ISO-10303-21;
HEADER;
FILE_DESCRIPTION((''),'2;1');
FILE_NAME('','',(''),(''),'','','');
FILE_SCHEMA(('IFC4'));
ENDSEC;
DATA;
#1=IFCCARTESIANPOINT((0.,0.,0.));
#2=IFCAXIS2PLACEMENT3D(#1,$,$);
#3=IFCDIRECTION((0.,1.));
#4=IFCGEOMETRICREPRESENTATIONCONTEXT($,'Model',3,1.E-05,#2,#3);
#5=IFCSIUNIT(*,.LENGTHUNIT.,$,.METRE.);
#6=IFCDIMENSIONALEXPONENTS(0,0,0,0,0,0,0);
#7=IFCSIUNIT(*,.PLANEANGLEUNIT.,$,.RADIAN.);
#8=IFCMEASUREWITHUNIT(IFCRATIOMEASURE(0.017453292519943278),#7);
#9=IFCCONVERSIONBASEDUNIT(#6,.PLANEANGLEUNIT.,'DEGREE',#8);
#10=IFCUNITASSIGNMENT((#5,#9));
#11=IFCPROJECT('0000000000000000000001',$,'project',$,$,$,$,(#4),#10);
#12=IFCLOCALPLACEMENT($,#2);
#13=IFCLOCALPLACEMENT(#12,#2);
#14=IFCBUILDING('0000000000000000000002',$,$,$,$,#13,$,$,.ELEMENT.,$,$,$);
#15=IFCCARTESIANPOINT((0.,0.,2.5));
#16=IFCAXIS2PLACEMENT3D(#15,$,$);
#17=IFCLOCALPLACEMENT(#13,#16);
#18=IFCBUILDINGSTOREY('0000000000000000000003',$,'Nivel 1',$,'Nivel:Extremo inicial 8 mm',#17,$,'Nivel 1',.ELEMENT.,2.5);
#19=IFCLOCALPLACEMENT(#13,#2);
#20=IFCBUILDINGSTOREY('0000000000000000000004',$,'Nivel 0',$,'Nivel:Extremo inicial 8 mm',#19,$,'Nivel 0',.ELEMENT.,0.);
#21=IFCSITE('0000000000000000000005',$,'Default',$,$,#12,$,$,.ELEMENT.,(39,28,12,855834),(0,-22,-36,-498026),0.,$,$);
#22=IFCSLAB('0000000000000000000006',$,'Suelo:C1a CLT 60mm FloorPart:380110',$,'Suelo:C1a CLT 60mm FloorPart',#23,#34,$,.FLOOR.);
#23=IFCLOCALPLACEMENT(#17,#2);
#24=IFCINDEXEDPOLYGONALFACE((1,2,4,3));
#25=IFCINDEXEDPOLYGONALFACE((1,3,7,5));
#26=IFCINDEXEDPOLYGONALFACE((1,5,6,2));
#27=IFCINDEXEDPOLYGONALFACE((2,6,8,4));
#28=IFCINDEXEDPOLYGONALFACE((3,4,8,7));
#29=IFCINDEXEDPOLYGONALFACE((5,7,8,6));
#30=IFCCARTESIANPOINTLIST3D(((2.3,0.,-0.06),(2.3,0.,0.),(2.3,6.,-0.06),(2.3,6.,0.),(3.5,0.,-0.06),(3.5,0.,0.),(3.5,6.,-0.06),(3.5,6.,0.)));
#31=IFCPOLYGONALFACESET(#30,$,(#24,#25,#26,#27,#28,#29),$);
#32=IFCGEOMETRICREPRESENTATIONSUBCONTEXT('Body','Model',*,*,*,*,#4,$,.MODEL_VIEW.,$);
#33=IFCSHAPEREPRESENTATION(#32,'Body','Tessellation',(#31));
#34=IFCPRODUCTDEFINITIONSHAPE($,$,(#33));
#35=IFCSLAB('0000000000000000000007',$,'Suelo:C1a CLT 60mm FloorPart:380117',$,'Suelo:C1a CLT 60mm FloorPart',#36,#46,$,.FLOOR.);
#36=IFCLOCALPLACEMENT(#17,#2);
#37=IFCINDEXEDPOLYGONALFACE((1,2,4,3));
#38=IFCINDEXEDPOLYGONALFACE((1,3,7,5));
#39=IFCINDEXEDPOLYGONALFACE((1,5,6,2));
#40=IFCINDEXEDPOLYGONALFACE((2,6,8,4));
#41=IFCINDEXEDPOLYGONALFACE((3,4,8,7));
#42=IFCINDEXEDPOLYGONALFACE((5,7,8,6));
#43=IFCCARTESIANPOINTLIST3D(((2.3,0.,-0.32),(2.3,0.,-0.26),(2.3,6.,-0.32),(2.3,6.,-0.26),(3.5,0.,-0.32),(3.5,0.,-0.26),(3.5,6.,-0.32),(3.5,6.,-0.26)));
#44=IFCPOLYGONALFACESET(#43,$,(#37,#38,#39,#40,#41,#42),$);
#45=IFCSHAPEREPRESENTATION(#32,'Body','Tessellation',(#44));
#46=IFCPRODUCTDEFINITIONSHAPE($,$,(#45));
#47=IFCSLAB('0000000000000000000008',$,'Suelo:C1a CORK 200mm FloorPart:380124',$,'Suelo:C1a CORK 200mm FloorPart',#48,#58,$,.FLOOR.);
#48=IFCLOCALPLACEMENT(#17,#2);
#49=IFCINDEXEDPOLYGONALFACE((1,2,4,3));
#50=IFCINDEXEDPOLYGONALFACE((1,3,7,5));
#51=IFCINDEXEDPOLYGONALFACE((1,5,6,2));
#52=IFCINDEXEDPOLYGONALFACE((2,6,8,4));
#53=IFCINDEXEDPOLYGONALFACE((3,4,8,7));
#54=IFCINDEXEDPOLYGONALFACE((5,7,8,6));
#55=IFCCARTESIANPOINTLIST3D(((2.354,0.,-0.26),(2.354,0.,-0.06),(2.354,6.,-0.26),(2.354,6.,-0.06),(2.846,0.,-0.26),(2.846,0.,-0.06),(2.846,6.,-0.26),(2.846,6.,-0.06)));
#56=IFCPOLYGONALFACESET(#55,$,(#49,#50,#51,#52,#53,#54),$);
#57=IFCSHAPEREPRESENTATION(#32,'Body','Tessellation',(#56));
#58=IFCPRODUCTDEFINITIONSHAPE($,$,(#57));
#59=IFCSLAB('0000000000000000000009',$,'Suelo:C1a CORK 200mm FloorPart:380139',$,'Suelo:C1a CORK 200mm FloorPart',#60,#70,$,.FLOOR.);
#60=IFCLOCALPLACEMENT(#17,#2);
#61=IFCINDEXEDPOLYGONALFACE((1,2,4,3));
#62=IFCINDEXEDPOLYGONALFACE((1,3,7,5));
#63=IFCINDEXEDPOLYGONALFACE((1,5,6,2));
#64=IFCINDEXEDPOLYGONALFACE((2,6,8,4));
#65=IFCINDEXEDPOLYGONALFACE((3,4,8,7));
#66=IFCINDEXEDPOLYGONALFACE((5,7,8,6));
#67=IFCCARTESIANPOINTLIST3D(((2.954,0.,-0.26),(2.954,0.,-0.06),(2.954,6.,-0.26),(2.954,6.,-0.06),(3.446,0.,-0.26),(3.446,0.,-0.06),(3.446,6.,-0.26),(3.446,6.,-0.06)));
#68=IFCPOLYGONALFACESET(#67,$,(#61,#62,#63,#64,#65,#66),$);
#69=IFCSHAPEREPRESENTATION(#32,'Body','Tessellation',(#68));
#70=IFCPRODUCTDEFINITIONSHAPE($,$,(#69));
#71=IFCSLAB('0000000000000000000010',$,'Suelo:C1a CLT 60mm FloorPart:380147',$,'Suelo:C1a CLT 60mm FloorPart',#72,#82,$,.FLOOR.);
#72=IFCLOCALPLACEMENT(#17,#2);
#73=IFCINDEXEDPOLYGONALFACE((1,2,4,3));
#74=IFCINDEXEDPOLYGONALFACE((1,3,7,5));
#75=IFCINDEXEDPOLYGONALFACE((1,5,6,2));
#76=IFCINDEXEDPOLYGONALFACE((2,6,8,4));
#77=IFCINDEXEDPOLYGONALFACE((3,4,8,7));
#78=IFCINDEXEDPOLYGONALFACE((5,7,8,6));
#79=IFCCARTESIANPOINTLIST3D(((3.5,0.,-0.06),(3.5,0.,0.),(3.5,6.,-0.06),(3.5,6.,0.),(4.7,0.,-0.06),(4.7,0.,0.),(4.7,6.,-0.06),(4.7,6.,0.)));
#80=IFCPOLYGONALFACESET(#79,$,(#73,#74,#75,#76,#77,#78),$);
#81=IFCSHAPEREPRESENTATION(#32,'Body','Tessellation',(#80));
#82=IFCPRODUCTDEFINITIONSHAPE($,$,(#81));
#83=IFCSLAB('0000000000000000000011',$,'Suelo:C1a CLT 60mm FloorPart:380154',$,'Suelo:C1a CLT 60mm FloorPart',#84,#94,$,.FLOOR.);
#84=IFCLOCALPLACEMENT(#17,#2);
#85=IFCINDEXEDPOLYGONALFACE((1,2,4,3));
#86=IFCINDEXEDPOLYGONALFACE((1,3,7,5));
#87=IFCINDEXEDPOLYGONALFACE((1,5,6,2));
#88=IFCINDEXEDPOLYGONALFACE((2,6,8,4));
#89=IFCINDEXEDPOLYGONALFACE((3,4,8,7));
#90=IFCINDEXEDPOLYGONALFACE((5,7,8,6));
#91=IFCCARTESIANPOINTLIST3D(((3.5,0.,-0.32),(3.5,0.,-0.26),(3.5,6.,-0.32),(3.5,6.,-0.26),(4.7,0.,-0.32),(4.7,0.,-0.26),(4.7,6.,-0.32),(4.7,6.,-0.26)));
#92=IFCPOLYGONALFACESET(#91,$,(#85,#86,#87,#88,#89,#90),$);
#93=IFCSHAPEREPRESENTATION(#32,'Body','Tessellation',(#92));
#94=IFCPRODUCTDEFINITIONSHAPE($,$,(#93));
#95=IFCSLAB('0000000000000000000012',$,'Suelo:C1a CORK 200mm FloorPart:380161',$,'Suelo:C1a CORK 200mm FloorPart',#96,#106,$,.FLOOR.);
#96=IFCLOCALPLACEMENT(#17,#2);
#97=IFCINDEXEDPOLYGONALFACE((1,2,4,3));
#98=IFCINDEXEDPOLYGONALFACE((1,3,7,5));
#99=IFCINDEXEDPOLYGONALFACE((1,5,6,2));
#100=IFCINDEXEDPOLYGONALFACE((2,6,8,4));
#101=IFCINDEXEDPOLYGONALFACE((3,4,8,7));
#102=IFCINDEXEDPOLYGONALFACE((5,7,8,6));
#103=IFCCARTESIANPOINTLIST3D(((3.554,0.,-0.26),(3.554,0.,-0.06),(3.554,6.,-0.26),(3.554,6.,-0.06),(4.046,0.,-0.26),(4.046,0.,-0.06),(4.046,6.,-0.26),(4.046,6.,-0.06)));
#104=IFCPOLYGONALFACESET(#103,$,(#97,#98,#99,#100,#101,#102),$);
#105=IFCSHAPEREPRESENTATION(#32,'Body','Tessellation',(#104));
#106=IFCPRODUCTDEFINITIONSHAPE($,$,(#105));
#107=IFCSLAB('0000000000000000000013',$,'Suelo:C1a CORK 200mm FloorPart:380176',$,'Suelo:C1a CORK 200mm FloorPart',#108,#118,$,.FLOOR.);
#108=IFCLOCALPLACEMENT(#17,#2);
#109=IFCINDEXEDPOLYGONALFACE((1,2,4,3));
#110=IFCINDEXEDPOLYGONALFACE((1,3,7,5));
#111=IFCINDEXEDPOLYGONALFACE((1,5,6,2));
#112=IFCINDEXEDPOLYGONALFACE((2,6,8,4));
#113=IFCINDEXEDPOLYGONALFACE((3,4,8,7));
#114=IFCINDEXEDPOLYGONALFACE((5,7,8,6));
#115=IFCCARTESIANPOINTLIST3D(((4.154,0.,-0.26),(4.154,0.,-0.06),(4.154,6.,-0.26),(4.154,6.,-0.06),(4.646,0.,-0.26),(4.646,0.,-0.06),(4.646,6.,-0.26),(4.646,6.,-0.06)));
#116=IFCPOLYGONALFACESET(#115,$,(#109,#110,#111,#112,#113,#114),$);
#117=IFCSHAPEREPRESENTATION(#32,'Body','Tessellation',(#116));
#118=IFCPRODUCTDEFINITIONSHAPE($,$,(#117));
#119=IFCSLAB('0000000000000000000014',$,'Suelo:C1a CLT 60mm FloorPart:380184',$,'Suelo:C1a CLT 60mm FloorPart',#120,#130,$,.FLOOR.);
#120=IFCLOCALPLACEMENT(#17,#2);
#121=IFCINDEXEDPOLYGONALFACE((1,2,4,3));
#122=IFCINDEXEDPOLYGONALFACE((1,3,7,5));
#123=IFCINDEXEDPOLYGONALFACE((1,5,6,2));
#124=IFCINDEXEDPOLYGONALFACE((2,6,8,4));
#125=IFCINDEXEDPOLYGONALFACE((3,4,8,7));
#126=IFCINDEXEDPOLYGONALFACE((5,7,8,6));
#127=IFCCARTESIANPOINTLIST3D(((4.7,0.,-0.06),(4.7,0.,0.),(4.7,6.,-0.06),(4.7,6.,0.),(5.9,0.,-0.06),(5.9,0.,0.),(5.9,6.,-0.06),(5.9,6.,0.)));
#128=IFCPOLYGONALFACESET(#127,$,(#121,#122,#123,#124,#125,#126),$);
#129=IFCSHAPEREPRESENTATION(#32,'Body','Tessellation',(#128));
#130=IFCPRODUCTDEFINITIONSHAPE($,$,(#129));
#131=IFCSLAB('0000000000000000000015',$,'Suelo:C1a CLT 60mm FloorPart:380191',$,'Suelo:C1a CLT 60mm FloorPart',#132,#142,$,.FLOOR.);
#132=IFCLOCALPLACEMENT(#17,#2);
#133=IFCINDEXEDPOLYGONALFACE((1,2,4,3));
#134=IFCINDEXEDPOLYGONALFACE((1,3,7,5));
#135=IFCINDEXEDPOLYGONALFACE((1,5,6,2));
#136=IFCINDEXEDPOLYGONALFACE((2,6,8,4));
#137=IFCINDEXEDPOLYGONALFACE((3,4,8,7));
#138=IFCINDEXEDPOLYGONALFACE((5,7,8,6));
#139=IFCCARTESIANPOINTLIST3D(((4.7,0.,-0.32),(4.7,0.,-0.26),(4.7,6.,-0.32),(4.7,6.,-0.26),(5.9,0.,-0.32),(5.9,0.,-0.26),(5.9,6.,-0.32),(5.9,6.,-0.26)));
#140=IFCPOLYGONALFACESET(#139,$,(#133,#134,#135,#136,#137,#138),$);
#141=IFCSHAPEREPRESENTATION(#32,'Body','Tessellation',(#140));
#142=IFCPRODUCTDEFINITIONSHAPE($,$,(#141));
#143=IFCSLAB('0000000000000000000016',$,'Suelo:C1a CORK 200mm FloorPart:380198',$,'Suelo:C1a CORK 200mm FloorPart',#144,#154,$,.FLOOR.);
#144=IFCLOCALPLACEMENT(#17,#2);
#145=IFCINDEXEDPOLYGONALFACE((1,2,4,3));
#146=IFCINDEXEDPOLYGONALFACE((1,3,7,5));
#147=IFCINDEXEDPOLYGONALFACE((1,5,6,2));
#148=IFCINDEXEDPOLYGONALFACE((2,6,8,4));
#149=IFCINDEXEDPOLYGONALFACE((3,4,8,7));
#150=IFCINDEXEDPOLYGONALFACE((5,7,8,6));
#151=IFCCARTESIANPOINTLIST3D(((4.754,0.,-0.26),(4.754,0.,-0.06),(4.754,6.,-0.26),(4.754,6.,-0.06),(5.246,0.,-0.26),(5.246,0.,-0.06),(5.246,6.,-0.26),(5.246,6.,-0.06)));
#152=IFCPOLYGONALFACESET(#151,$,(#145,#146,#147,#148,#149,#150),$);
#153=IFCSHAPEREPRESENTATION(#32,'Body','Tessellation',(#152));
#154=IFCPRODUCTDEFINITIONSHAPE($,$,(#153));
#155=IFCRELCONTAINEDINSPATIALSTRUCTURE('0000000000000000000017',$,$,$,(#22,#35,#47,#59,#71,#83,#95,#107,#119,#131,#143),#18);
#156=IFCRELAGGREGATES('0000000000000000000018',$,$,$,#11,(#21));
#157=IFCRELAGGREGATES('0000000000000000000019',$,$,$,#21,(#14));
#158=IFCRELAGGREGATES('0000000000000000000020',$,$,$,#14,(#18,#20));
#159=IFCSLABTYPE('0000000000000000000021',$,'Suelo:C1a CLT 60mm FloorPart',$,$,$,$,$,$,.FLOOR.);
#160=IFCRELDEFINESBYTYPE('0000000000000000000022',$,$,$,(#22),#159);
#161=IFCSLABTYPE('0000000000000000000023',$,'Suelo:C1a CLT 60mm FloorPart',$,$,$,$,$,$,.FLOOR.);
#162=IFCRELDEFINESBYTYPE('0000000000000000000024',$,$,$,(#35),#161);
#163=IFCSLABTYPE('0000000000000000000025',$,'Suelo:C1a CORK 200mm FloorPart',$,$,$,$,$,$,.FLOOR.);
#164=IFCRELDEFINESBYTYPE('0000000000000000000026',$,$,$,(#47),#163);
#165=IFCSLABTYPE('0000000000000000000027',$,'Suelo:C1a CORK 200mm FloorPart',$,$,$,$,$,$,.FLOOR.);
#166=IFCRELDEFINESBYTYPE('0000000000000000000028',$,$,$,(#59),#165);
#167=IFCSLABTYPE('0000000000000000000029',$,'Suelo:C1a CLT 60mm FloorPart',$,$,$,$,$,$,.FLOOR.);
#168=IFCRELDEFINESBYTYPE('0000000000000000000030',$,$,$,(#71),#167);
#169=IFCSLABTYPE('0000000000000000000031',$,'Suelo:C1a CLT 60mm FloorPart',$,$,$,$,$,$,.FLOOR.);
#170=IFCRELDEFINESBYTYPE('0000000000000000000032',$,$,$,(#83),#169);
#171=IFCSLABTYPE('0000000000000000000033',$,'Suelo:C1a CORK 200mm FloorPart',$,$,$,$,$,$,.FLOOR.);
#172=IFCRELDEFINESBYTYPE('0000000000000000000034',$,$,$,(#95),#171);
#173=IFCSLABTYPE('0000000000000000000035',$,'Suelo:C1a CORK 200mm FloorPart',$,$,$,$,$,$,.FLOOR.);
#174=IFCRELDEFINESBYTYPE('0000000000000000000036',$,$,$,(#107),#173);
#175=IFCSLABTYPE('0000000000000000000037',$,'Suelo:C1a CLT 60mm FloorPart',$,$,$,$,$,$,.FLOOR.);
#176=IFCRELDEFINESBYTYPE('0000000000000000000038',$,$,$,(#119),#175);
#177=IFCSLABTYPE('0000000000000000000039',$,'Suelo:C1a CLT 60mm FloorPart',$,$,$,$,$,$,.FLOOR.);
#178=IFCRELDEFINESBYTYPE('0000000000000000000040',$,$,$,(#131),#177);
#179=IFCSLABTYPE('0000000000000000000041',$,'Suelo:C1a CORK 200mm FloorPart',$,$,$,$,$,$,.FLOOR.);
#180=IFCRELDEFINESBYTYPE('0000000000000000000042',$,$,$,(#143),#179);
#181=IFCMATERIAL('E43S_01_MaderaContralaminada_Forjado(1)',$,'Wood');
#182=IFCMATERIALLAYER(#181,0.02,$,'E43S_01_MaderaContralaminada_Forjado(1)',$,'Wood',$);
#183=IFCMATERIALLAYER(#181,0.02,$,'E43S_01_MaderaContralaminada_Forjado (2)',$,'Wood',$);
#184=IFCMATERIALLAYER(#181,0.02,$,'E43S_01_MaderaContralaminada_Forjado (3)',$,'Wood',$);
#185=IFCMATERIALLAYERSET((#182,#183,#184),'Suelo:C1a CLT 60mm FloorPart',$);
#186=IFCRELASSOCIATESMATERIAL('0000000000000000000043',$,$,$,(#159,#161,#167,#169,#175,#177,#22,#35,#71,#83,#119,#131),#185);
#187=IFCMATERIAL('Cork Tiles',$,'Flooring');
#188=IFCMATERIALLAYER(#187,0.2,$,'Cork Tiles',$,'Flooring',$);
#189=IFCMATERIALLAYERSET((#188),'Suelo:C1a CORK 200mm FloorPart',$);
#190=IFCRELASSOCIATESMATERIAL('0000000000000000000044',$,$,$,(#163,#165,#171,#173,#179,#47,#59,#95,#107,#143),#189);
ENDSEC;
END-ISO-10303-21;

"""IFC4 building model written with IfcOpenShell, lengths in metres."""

from ifc_helpers import new_model, entity, si_unit, converted_unit, direction, frame, frame_2d, origin, origin_2d_with_axis, place, context, subcontext, project, spatial, rectangle, extrude, material, layer, layer_set, layer_usage, type_object, element, save


model = new_model("IFC4")

# Units and contexts
model_context = context("Model", 3, precision=1e-05, world=origin(), true_north=direction((0.0, 1.0)))
body_context = subcontext(model_context, "Body", "Model", "MODEL_VIEW")
ifc_project = project(units=[si_unit("LENGTHUNIT", "METRE"), converted_unit("PLANEANGLEUNIT", "DEGREE", entity("IfcRatioMeasure", 0.017453292519943278), si_unit("PLANEANGLEUNIT", "RADIAN"), dimensions=[0, 0, 0, 0, 0, 0, 0])], contexts=[model_context])

# Site, building, storey
site_placement = place(None, origin())
site = spatial("IfcSite", under=ifc_project, at=site_placement, Name="Default", CompositionType="ELEMENT", RefLatitude=(39, 28, 12, 855834), RefLongitude=(0, -22, -36, -498026), RefElevation=0.0)
building_placement = place(site_placement, origin())
building = spatial("IfcBuilding", under=site, at=building_placement, CompositionType="ELEMENT")
storey_1_placement = place(building_placement, frame((0.0, 0.0, 2.5)))
storey_1 = spatial("IfcBuildingStorey", under=building, at=storey_1_placement, Name="Nivel 1", ObjectType="Nivel:Extremo inicial 8 mm", LongName="Nivel 1", CompositionType="ELEMENT", Elevation=2.5)

# Slabs
ifc_material_1 = material(Name="E43S_01_MaderaContralaminada_Forjado(1)", Category="Wood")
ifc_layer_1 = layer(ifc_material_1, 0.02, Name="E43S_01_MaderaContralaminada_Forjado(1)", Category="Wood")
ifc_layer_2 = layer(ifc_material_1, 0.02, Name="E43S_01_MaderaContralaminada_Forjado (2)", Category="Wood")
ifc_layer_3 = layer(ifc_material_1, 0.02, Name="E43S_01_MaderaContralaminada_Forjado (3)", Category="Wood")
ifc_layer_set_1 = layer_set([ifc_layer_1, ifc_layer_2, ifc_layer_3], Name="Suelo:C1a CLT 60mm FloorPart")
ifc_layer_usage_1 = layer_usage(ifc_layer_set_1, "AXIS3", "POSITIVE", 0.0)
slab_type_1 = type_object("IfcSlabType", Name="Suelo:C1a CLT 60mm FloorPart", PredefinedType="FLOOR", material=ifc_layer_set_1)
slab_1_placement = place(storey_1_placement, origin())
element("IfcSlab", 1, at=slab_1_placement, inside=storey_1, type_object=slab_type_1, material=ifc_layer_usage_1, Name="Suelo:C1a CLT 60mm FloorPart:380110", ObjectType="Suelo:C1a CLT 60mm FloorPart", PredefinedType="FLOOR", context=body_context, shape_type="SweptSolid", body=[
    extrude(rectangle(XDim=6.0, YDim=1.2, at=frame_2d((0.0, 0.0), x_axis=(1.0, 0.0))), frame((2.9, 3.0, 0.0), z_axis=(0.0, 0.0, -1.0), x_axis=(0.0, 1.0, 0.0)), (0.0, 0.0, 1.0), 0.06),
])
ifc_layer_usage_2 = layer_usage(ifc_layer_set_1, "AXIS3", "POSITIVE", 0.0)
slab_type_2 = type_object("IfcSlabType", Name="Suelo:C1a CLT 60mm FloorPart", PredefinedType="FLOOR", material=ifc_layer_set_1)
slab_2_placement = place(storey_1_placement, origin())
element("IfcSlab", 2, at=slab_2_placement, inside=storey_1, type_object=slab_type_2, material=ifc_layer_usage_2, Name="Suelo:C1a CLT 60mm FloorPart:380117", ObjectType="Suelo:C1a CLT 60mm FloorPart", PredefinedType="FLOOR", context=body_context, shape_type="SweptSolid", body=[
    extrude(rectangle(XDim=6.0, YDim=1.2, at=frame_2d((0.0, 0.0), x_axis=(1.0, 0.0))), frame((2.9, 3.0, -0.26), z_axis=(0.0, 0.0, -1.0), x_axis=(0.0, 1.0, 0.0)), (0.0, 0.0, 1.0), 0.06),
])
ifc_material_2 = material(Name="Cork Tiles", Category="Flooring")
ifc_layer_4 = layer(ifc_material_2, 0.2, Name="Cork Tiles", Category="Flooring")
ifc_layer_set_2 = layer_set([ifc_layer_4], Name="Suelo:C1a CORK 200mm FloorPart")
ifc_layer_usage_3 = layer_usage(ifc_layer_set_2, "AXIS3", "POSITIVE", 0.0)
slab_type_3 = type_object("IfcSlabType", Name="Suelo:C1a CORK 200mm FloorPart", PredefinedType="FLOOR", material=ifc_layer_set_2)
slab_3_placement = place(storey_1_placement, origin())
element("IfcSlab", 3, at=slab_3_placement, inside=storey_1, type_object=slab_type_3, material=ifc_layer_usage_3, Name="Suelo:C1a CORK 200mm FloorPart:380124", ObjectType="Suelo:C1a CORK 200mm FloorPart", PredefinedType="FLOOR", context=body_context, shape_type="SweptSolid", body=[
    extrude(rectangle(XDim=6.0, YDim=0.492, at=frame_2d((0.0, 0.0), x_axis=(1.0, 0.0))), frame((2.6, 3.0, -0.06), z_axis=(0.0, 0.0, -1.0), x_axis=(0.0, 1.0, 0.0)), (0.0, 0.0, 1.0), 0.2),
])
ifc_layer_usage_4 = layer_usage(ifc_layer_set_2, "AXIS3", "POSITIVE", 0.0)
slab_type_4 = type_object("IfcSlabType", Name="Suelo:C1a CORK 200mm FloorPart", PredefinedType="FLOOR", material=ifc_layer_set_2)
slab_4_placement = place(storey_1_placement, origin())
element("IfcSlab", 4, at=slab_4_placement, inside=storey_1, type_object=slab_type_4, material=ifc_layer_usage_4, Name="Suelo:C1a CORK 200mm FloorPart:380139", ObjectType="Suelo:C1a CORK 200mm FloorPart", PredefinedType="FLOOR", context=body_context, shape_type="SweptSolid", body=[
    extrude(rectangle(XDim=6.0, YDim=0.492, at=frame_2d((0.0, 0.0), x_axis=(1.0, 0.0))), frame((3.2, 3.0, -0.06), z_axis=(0.0, 0.0, -1.0), x_axis=(0.0, 1.0, 0.0)), (0.0, 0.0, 1.0), 0.2),
])
ifc_layer_usage_5 = layer_usage(ifc_layer_set_1, "AXIS3", "POSITIVE", 0.0)
slab_type_5 = type_object("IfcSlabType", Name="Suelo:C1a CLT 60mm FloorPart", PredefinedType="FLOOR", material=ifc_layer_set_1)
slab_5_placement = place(storey_1_placement, origin())
element("IfcSlab", 5, at=slab_5_placement, inside=storey_1, type_object=slab_type_5, material=ifc_layer_usage_5, Name="Suelo:C1a CLT 60mm FloorPart:380147", ObjectType="Suelo:C1a CLT 60mm FloorPart", PredefinedType="FLOOR", context=body_context, shape_type="SweptSolid", body=[
    extrude(rectangle(XDim=6.0, YDim=1.2, at=frame_2d((0.0, 0.0), x_axis=(1.0, 0.0))), frame((4.1, 3.0, 0.0), z_axis=(0.0, 0.0, -1.0), x_axis=(0.0, 1.0, 0.0)), (0.0, 0.0, 1.0), 0.06),
])
ifc_layer_usage_6 = layer_usage(ifc_layer_set_1, "AXIS3", "POSITIVE", 0.0)
slab_type_6 = type_object("IfcSlabType", Name="Suelo:C1a CLT 60mm FloorPart", PredefinedType="FLOOR", material=ifc_layer_set_1)
slab_6_placement = place(storey_1_placement, origin())
element("IfcSlab", 6, at=slab_6_placement, inside=storey_1, type_object=slab_type_6, material=ifc_layer_usage_6, Name="Suelo:C1a CLT 60mm FloorPart:380154", ObjectType="Suelo:C1a CLT 60mm FloorPart", PredefinedType="FLOOR", context=body_context, shape_type="SweptSolid", body=[
    extrude(rectangle(XDim=6.0, YDim=1.2, at=frame_2d((0.0, 0.0), x_axis=(1.0, 0.0))), frame((4.1, 3.0, -0.26), z_axis=(0.0, 0.0, -1.0), x_axis=(0.0, 1.0, 0.0)), (0.0, 0.0, 1.0), 0.06),
])
ifc_layer_usage_7 = layer_usage(ifc_layer_set_2, "AXIS3", "POSITIVE", 0.0)
slab_type_7 = type_object("IfcSlabType", Name="Suelo:C1a CORK 200mm FloorPart", PredefinedType="FLOOR", material=ifc_layer_set_2)
slab_7_placement = place(storey_1_placement, origin())
element("IfcSlab", 7, at=slab_7_placement, inside=storey_1, type_object=slab_type_7, material=ifc_layer_usage_7, Name="Suelo:C1a CORK 200mm FloorPart:380161", ObjectType="Suelo:C1a CORK 200mm FloorPart", PredefinedType="FLOOR", context=body_context, shape_type="SweptSolid", body=[
    extrude(rectangle(XDim=6.0, YDim=0.492, at=frame_2d((0.0, 0.0), x_axis=(1.0, 0.0))), frame((3.8, 3.0, -0.06), z_axis=(0.0, 0.0, -1.0), x_axis=(0.0, 1.0, 0.0)), (0.0, 0.0, 1.0), 0.2),
])
ifc_layer_usage_8 = layer_usage(ifc_layer_set_2, "AXIS3", "POSITIVE", 0.0)
slab_type_8 = type_object("IfcSlabType", Name="Suelo:C1a CORK 200mm FloorPart", PredefinedType="FLOOR", material=ifc_layer_set_2)
slab_8_placement = place(storey_1_placement, origin())
element("IfcSlab", 8, at=slab_8_placement, inside=storey_1, type_object=slab_type_8, material=ifc_layer_usage_8, Name="Suelo:C1a CORK 200mm FloorPart:380176", ObjectType="Suelo:C1a CORK 200mm FloorPart", PredefinedType="FLOOR", context=body_context, shape_type="SweptSolid", body=[
    extrude(rectangle(XDim=6.0, YDim=0.492, at=frame_2d((0.0, 0.0), x_axis=(1.0, 0.0))), frame((4.4, 3.0, -0.06), z_axis=(0.0, 0.0, -1.0), x_axis=(0.0, 1.0, 0.0)), (0.0, 0.0, 1.0), 0.2),
])
ifc_layer_usage_9 = layer_usage(ifc_layer_set_1, "AXIS3", "POSITIVE", 0.0)
slab_type_9 = type_object("IfcSlabType", Name="Suelo:C1a CLT 60mm FloorPart", PredefinedType="FLOOR", material=ifc_layer_set_1)
slab_9_placement = place(storey_1_placement, origin())
element("IfcSlab", 9, at=slab_9_placement, inside=storey_1, type_object=slab_type_9, material=ifc_layer_usage_9, Name="Suelo:C1a CLT 60mm FloorPart:380184", ObjectType="Suelo:C1a CLT 60mm FloorPart", PredefinedType="FLOOR", context=body_context, shape_type="SweptSolid", body=[
    extrude(rectangle(XDim=6.0, YDim=1.2, at=frame_2d((0.0, 0.0), x_axis=(1.0, 0.0))), frame((5.3, 3.0, 0.0), z_axis=(0.0, 0.0, -1.0), x_axis=(0.0, 1.0, 0.0)), (0.0, 0.0, 1.0), 0.06),
])
ifc_layer_usage_10 = layer_usage(ifc_layer_set_1, "AXIS3", "POSITIVE", 0.0)
slab_type_10 = type_object("IfcSlabType", Name="Suelo:C1a CLT 60mm FloorPart", PredefinedType="FLOOR", material=ifc_layer_set_1)
slab_10_placement = place(storey_1_placement, origin())
element("IfcSlab", 10, at=slab_10_placement, inside=storey_1, type_object=slab_type_10, material=ifc_layer_usage_10, Name="Suelo:C1a CLT 60mm FloorPart:380191", ObjectType="Suelo:C1a CLT 60mm FloorPart", PredefinedType="FLOOR", context=body_context, shape_type="SweptSolid", body=[
    extrude(rectangle(XDim=6.0, YDim=1.2, at=frame_2d((0.0, 0.0), x_axis=(1.0, 0.0))), frame((5.3, 3.0, -0.26), z_axis=(0.0, 0.0, -1.0), x_axis=(0.0, 1.0, 0.0)), (0.0, 0.0, 1.0), 0.06),
])
ifc_layer_usage_11 = layer_usage(ifc_layer_set_2, "AXIS3", "POSITIVE", 0.0)
slab_type_11 = type_object("IfcSlabType", Name="Suelo:C1a CORK 200mm FloorPart", PredefinedType="FLOOR", material=ifc_layer_set_2)
slab_11_placement = place(storey_1_placement, origin())
element("IfcSlab", 11, at=slab_11_placement, inside=storey_1, type_object=slab_type_11, material=ifc_layer_usage_11, Name="Suelo:C1a CORK 200mm FloorPart:380198", ObjectType="Suelo:C1a CORK 200mm FloorPart", PredefinedType="FLOOR", context=body_context, shape_type="SweptSolid", body=[
    extrude(rectangle(XDim=6.0, YDim=0.492, at=origin_2d_with_axis()), frame((5.0, 3.0, -0.06), z_axis=(0.0, 0.0, -1.0), x_axis=(0.0, 1.0, 0.0)), (0.0, 0.0, 1.0), 0.2),
])

# Shared definitions
storey_2_placement = place(building_placement, origin())
storey_2 = spatial("IfcBuildingStorey", under=building, at=storey_2_placement, Name="Nivel 0", ObjectType="Nivel:Extremo inicial 8 mm", LongName="Nivel 0", CompositionType="ELEMENT", Elevation=0.0)

save(model, "model.ifc")
